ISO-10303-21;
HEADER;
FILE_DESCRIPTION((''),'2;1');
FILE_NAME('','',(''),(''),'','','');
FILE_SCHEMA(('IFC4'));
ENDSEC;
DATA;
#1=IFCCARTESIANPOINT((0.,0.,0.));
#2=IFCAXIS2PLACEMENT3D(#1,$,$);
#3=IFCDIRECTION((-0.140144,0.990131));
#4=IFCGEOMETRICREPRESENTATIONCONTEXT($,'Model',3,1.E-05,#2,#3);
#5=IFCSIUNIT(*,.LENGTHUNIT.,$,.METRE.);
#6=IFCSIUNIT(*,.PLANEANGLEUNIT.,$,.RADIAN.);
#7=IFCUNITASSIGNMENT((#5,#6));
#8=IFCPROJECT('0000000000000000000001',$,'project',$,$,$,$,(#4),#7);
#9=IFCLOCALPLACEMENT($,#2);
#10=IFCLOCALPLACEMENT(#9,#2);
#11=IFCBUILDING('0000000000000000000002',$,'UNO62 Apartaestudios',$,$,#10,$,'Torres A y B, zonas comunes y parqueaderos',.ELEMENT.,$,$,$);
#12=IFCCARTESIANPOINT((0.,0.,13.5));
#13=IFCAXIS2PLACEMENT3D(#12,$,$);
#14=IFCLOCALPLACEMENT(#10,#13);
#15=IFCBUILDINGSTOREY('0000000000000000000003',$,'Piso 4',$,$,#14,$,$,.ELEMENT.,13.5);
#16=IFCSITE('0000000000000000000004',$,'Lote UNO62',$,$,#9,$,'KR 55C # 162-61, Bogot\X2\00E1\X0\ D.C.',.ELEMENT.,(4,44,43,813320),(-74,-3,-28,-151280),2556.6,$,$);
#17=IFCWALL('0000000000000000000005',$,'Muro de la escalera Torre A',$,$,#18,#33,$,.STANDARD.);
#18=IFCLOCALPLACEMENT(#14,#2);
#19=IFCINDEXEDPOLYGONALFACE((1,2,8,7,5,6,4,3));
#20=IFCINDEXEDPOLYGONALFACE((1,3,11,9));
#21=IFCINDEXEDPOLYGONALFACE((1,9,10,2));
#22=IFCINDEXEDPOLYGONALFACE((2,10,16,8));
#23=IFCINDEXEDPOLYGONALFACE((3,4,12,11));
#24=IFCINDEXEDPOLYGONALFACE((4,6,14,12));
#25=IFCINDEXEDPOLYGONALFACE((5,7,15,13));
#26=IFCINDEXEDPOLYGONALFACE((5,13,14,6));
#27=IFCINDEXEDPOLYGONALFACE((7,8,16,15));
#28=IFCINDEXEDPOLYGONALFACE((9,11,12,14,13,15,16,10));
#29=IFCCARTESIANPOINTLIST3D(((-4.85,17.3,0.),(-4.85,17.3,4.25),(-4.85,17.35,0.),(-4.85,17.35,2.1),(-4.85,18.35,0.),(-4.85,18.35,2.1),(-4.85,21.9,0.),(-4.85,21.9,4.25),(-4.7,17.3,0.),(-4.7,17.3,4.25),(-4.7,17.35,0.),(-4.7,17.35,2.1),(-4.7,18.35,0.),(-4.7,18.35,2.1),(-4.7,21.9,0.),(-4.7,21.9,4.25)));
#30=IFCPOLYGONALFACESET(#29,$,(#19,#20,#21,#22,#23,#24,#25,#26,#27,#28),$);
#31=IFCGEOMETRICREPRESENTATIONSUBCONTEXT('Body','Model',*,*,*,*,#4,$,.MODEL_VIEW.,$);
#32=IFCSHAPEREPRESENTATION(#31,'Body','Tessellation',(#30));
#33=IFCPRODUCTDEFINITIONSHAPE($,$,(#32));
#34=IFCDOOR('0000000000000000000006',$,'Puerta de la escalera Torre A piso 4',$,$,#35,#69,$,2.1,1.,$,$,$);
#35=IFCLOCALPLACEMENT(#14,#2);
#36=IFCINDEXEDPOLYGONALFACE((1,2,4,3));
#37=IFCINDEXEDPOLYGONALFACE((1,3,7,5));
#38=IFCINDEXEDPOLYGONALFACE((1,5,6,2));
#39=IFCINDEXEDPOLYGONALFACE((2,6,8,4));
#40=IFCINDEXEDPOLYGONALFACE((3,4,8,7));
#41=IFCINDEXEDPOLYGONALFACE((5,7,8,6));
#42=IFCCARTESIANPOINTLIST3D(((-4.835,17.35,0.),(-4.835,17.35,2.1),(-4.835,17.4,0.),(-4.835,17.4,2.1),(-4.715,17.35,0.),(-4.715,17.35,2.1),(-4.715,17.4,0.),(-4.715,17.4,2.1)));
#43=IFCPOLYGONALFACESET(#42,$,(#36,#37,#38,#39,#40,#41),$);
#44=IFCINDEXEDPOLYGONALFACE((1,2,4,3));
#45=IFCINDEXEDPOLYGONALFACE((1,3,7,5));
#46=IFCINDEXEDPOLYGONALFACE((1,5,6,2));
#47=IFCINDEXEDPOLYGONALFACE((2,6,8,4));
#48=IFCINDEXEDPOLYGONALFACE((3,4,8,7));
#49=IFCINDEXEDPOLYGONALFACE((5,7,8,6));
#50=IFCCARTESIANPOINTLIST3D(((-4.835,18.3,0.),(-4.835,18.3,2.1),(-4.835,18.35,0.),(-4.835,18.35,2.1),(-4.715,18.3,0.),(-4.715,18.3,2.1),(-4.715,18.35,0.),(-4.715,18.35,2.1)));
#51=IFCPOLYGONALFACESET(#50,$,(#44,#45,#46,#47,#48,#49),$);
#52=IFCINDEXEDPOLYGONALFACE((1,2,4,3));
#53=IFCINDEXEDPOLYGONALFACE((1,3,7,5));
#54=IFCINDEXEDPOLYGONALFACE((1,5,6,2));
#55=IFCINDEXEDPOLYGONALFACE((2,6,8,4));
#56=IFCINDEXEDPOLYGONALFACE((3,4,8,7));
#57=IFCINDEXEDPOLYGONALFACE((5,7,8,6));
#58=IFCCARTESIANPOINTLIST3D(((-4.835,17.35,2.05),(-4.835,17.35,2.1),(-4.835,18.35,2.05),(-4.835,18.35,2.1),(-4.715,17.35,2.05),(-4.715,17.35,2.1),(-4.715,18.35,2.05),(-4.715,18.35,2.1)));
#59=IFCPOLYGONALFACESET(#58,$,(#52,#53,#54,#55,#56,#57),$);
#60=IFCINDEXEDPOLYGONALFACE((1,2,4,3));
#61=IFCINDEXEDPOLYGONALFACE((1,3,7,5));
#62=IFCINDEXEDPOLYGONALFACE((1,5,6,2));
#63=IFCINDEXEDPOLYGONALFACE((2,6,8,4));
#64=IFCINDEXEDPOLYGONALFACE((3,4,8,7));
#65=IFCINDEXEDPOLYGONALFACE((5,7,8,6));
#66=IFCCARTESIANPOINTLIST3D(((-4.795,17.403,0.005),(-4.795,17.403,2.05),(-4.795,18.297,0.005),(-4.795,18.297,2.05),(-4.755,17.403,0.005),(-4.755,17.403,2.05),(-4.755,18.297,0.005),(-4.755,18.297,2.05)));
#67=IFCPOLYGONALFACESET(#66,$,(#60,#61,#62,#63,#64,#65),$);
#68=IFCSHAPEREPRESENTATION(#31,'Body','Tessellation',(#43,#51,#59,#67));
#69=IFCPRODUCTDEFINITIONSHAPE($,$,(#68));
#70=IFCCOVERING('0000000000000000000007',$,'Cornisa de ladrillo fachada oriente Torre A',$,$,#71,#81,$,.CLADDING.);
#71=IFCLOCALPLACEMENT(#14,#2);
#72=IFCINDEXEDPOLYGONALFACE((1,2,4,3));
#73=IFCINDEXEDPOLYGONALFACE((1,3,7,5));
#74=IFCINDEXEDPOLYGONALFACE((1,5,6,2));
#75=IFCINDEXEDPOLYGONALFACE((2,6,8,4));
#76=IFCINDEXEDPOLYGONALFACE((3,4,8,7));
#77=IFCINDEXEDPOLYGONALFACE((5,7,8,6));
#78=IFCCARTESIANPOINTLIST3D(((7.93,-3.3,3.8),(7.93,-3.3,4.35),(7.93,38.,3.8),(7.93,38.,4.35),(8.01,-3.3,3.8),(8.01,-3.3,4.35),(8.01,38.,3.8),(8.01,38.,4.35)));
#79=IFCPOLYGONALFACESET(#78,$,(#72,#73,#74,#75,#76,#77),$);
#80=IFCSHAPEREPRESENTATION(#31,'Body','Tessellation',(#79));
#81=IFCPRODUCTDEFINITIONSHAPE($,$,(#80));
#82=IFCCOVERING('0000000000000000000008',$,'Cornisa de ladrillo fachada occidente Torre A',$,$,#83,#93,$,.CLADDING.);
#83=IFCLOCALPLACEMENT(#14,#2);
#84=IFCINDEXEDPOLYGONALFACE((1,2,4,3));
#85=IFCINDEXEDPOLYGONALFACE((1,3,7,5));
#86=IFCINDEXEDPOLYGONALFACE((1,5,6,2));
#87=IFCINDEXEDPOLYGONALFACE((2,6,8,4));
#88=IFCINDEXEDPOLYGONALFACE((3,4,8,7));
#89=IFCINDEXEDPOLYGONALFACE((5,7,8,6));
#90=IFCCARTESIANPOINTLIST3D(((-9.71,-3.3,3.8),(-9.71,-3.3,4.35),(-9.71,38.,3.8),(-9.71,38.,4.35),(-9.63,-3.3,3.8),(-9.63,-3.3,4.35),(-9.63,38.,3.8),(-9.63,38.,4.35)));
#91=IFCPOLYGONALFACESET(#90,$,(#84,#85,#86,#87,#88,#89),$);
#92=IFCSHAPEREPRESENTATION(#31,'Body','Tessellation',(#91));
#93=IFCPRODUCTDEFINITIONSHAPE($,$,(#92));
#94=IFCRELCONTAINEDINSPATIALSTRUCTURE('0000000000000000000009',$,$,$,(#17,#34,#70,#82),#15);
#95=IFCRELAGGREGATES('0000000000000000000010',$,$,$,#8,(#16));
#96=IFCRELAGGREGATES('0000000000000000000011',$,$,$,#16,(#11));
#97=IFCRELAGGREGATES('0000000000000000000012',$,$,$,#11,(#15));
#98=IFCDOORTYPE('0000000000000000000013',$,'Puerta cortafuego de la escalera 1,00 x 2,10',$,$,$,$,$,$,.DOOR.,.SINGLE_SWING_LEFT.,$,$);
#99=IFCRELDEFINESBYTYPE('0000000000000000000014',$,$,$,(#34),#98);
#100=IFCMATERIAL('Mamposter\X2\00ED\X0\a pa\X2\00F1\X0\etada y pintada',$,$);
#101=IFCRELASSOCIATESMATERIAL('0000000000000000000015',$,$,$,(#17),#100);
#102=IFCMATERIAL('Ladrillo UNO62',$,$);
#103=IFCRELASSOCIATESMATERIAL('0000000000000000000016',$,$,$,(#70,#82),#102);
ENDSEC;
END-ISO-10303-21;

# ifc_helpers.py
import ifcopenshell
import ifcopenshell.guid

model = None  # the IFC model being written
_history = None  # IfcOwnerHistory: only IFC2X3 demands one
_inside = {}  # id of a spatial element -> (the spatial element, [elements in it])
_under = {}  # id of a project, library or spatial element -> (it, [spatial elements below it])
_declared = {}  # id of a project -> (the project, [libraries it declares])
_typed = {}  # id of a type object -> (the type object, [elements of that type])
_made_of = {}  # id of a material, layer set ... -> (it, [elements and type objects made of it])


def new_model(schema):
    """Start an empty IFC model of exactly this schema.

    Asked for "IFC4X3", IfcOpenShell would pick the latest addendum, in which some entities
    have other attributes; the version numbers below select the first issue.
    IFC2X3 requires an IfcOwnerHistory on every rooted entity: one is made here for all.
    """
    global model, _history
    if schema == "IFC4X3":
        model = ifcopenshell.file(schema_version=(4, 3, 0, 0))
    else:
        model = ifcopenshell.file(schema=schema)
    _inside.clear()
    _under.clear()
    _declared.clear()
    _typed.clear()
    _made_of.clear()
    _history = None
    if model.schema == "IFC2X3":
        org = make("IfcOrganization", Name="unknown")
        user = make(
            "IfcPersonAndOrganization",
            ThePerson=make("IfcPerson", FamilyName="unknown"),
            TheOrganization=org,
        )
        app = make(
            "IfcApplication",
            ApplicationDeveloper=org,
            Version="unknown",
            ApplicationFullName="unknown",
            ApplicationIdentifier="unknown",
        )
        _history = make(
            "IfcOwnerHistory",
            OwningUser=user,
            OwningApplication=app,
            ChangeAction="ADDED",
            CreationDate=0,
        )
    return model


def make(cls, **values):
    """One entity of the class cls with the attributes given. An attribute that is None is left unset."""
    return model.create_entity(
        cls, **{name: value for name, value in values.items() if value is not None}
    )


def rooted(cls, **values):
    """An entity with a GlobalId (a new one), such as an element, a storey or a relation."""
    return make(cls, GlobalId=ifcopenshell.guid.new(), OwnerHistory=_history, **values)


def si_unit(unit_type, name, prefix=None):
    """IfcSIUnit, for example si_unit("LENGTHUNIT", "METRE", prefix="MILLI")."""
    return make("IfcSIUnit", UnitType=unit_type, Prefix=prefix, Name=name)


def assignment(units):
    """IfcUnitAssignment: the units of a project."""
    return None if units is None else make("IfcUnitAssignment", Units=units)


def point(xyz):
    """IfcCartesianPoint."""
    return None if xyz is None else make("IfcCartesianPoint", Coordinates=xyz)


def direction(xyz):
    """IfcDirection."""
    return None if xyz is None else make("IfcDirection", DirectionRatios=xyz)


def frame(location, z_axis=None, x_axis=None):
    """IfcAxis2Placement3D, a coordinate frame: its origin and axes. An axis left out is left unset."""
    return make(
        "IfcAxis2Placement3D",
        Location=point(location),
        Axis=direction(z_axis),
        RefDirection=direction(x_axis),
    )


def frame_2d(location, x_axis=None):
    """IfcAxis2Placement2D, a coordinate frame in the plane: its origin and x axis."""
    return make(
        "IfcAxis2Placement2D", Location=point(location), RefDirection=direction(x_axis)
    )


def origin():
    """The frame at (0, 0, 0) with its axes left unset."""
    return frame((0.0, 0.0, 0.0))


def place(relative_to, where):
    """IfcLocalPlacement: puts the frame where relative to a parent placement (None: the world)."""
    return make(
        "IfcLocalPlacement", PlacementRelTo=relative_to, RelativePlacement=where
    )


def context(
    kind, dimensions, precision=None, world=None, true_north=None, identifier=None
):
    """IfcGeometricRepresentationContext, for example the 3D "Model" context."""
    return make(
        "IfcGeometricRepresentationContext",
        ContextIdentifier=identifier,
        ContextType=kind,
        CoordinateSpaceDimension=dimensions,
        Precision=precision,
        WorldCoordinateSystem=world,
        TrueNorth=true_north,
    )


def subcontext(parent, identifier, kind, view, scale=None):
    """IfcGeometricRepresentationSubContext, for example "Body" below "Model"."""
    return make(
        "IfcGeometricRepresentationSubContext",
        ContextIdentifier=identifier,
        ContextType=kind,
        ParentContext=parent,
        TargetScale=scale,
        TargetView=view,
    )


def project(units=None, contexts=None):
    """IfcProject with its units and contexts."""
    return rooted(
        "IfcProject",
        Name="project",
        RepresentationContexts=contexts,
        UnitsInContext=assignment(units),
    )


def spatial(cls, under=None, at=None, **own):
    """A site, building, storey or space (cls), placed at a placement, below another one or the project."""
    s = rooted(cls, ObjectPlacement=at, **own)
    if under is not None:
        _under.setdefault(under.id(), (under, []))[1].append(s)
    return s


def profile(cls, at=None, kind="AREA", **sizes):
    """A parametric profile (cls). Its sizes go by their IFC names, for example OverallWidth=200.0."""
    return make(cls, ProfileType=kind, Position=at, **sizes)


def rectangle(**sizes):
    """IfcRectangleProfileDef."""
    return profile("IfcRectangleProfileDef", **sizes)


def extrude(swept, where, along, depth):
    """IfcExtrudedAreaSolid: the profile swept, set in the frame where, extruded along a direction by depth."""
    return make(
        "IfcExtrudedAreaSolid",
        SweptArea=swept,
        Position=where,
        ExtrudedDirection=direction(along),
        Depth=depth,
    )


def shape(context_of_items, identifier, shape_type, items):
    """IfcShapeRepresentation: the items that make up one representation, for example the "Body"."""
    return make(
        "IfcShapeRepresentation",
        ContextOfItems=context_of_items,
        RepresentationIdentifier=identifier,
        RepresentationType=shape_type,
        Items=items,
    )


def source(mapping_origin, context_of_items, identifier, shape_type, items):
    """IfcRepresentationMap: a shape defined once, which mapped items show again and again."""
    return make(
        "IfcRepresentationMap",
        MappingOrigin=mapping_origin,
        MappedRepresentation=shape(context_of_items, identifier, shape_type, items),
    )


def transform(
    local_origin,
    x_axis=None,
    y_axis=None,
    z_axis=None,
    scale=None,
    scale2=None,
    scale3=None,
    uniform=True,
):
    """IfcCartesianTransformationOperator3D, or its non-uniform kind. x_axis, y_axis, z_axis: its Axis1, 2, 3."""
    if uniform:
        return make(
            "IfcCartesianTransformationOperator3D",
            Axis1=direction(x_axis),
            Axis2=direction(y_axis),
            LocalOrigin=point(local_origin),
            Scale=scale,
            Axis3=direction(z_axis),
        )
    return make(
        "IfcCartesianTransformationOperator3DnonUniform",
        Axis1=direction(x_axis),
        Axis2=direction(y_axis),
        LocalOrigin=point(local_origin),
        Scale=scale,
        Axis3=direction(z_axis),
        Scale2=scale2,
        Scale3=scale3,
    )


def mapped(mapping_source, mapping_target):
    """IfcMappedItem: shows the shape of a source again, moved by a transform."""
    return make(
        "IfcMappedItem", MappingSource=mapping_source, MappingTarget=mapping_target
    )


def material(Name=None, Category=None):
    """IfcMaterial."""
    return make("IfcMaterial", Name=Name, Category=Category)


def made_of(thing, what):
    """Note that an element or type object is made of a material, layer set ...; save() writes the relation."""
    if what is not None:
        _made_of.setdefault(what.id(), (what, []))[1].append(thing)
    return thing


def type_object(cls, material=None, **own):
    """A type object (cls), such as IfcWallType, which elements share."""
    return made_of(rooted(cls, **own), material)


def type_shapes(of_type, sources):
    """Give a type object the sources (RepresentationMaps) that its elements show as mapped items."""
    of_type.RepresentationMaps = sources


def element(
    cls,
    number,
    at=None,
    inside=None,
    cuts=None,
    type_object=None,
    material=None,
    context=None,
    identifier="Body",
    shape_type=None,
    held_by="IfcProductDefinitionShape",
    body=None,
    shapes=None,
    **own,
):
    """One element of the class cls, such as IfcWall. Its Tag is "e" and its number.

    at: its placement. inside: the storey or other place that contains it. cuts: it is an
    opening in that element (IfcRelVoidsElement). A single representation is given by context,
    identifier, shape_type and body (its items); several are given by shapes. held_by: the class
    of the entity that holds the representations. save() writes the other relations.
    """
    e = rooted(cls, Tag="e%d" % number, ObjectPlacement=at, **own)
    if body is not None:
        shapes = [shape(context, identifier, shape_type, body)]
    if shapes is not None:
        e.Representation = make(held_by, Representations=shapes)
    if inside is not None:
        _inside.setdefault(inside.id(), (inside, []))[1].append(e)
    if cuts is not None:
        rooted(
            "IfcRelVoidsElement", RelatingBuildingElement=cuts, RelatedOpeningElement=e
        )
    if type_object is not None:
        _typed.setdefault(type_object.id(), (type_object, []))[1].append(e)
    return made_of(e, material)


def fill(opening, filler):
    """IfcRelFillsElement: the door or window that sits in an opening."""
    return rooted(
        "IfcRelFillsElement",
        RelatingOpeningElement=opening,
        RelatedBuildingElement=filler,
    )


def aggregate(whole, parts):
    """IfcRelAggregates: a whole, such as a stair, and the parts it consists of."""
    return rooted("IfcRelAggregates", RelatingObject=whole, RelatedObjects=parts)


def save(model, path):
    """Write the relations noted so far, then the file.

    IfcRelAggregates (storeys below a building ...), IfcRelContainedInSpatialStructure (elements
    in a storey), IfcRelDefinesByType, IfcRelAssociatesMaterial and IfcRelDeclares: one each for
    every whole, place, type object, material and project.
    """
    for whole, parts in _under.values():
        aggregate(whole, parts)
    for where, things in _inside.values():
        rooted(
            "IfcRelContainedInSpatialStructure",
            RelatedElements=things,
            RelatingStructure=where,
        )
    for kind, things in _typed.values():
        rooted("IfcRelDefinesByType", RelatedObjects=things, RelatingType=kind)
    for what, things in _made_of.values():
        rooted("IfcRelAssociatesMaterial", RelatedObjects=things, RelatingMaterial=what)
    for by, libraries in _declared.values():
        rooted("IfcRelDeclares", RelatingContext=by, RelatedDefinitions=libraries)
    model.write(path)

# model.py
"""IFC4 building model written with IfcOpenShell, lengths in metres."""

from ifc_helpers import new_model, si_unit, direction, frame, frame_2d, origin, place, context, subcontext, project, spatial, rectangle, extrude, source, transform, mapped, material, type_object, type_shapes, element, fill, save


model = new_model("IFC4")

# Units and contexts
model_context = context("Model", 3, precision=1e-05, world=origin(), true_north=direction((-0.140144, 0.990131)))
body_context = subcontext(model_context, "Body", "Model", "MODEL_VIEW")
ifc_project = project(units=[si_unit("LENGTHUNIT", "METRE"), si_unit("PLANEANGLEUNIT", "RADIAN")], contexts=[model_context])

# Site, building, storey
site_placement = place(None, origin())
site = spatial("IfcSite", under=ifc_project, at=site_placement, Name="Lote UNO62", LongName="KR 55C # 162-61, Bogotá D.C.", CompositionType="ELEMENT", RefLatitude=(4, 44, 43, 813320), RefLongitude=(-74, -3, -28, -151280), RefElevation=2556.6)
building_placement = place(site_placement, origin())
building = spatial("IfcBuilding", under=site, at=building_placement, Name="UNO62 Apartaestudios", LongName="Torres A y B, zonas comunes y parqueaderos", CompositionType="ELEMENT")
storey_placement = place(building_placement, frame((0.0, 0.0, 13.5)))
storey = spatial("IfcBuildingStorey", under=building, at=storey_placement, Name="Piso 4", CompositionType="ELEMENT", Elevation=13.5)

# Shared definitions
ifc_material_1 = material(Name="Ladrillo UNO62")

# Wall, opening, door
ifc_material_2 = material(Name="Mampostería pañetada y pintada")
wall_1_placement = place(storey_placement, origin())
wall_1 = element("IfcWall", 1, at=wall_1_placement, inside=storey, material=ifc_material_2, Name="Muro de la escalera Torre A", PredefinedType="STANDARD", context=body_context, shape_type="SweptSolid", body=[
    extrude(rectangle(XDim=0.15, YDim=4.6, at=frame_2d((-4.775, 19.6))), origin(), (0.0, 0.0, 1.0), 4.25),
])
opening_1_placement = place(wall_1_placement, origin())
opening_1 = element("IfcOpeningElement", 2, at=opening_1_placement, cuts=wall_1, PredefinedType="OPENING", context=body_context, shape_type="SweptSolid", body=[
    extrude(rectangle(XDim=0.25, YDim=1.0, at=frame_2d((-4.775, 17.85))), origin(), (0.0, 0.0, 1.0), 2.1),
])
door_type_1 = type_object("IfcDoorType", Name="Puerta cortafuego de la escalera 1,00 x 2,10", OperationType="SINGLE_SWING_LEFT", PredefinedType="DOOR")
shared_shape_1 = source(origin(), body_context, "Body", "SweptSolid", [
    extrude(rectangle(XDim=0.05, YDim=0.12, at=frame_2d((0.025, 0.0))), origin(), (0.0, 0.0, 1.0), 2.1),
    extrude(rectangle(XDim=0.05, YDim=0.12, at=frame_2d((0.975, 0.0))), origin(), (0.0, 0.0, 1.0), 2.1),
    extrude(rectangle(XDim=1.0, YDim=0.12, at=frame_2d((0.5, 0.0))), frame((0.0, 0.0, 2.05)), (0.0, 0.0, 1.0), 0.05),
    extrude(rectangle(XDim=0.894, YDim=0.04, at=frame_2d((0.5, 0.0))), frame((0.0, 0.0, 0.005)), (0.0, 0.0, 1.0), 2.045),
])
type_shapes(door_type_1, [shared_shape_1])
door_1_placement = place(storey_placement, frame((-4.775, 17.35, 0.0), z_axis=(0.0, 0.0, 1.0), x_axis=(0.0, 1.0, 0.0)))
door_1 = element("IfcDoor", 3, at=door_1_placement, inside=storey, type_object=door_type_1, Name="Puerta de la escalera Torre A piso 4", OverallHeight=2.1, OverallWidth=1.0, context=body_context, shape_type="MappedRepresentation", body=[
    mapped(shared_shape_1, transform((0.0, 0.0, 0.0))),
])
fill(opening_1, door_1)

# Coverings
covering_1_placement = place(storey_placement, origin())
element("IfcCovering", 4, at=covering_1_placement, inside=storey, material=ifc_material_1, Name="Cornisa de ladrillo fachada oriente Torre A", PredefinedType="CLADDING", context=body_context, shape_type="SweptSolid", body=[
    extrude(rectangle(XDim=0.08, YDim=41.3, at=frame_2d((7.97, 17.35))), frame((0.0, 0.0, 3.8)), (0.0, 0.0, 1.0), 0.55),
])
covering_2_placement = place(storey_placement, origin())
element("IfcCovering", 5, at=covering_2_placement, inside=storey, material=ifc_material_1, Name="Cornisa de ladrillo fachada occidente Torre A", PredefinedType="CLADDING", context=body_context, shape_type="SweptSolid", body=[
    extrude(rectangle(XDim=0.08, YDim=41.3, at=frame_2d((-9.67, 17.35))), frame((0.0, 0.0, 3.8)), (0.0, 0.0, 1.0), 0.55),
])

save(model, "model.ifc")
